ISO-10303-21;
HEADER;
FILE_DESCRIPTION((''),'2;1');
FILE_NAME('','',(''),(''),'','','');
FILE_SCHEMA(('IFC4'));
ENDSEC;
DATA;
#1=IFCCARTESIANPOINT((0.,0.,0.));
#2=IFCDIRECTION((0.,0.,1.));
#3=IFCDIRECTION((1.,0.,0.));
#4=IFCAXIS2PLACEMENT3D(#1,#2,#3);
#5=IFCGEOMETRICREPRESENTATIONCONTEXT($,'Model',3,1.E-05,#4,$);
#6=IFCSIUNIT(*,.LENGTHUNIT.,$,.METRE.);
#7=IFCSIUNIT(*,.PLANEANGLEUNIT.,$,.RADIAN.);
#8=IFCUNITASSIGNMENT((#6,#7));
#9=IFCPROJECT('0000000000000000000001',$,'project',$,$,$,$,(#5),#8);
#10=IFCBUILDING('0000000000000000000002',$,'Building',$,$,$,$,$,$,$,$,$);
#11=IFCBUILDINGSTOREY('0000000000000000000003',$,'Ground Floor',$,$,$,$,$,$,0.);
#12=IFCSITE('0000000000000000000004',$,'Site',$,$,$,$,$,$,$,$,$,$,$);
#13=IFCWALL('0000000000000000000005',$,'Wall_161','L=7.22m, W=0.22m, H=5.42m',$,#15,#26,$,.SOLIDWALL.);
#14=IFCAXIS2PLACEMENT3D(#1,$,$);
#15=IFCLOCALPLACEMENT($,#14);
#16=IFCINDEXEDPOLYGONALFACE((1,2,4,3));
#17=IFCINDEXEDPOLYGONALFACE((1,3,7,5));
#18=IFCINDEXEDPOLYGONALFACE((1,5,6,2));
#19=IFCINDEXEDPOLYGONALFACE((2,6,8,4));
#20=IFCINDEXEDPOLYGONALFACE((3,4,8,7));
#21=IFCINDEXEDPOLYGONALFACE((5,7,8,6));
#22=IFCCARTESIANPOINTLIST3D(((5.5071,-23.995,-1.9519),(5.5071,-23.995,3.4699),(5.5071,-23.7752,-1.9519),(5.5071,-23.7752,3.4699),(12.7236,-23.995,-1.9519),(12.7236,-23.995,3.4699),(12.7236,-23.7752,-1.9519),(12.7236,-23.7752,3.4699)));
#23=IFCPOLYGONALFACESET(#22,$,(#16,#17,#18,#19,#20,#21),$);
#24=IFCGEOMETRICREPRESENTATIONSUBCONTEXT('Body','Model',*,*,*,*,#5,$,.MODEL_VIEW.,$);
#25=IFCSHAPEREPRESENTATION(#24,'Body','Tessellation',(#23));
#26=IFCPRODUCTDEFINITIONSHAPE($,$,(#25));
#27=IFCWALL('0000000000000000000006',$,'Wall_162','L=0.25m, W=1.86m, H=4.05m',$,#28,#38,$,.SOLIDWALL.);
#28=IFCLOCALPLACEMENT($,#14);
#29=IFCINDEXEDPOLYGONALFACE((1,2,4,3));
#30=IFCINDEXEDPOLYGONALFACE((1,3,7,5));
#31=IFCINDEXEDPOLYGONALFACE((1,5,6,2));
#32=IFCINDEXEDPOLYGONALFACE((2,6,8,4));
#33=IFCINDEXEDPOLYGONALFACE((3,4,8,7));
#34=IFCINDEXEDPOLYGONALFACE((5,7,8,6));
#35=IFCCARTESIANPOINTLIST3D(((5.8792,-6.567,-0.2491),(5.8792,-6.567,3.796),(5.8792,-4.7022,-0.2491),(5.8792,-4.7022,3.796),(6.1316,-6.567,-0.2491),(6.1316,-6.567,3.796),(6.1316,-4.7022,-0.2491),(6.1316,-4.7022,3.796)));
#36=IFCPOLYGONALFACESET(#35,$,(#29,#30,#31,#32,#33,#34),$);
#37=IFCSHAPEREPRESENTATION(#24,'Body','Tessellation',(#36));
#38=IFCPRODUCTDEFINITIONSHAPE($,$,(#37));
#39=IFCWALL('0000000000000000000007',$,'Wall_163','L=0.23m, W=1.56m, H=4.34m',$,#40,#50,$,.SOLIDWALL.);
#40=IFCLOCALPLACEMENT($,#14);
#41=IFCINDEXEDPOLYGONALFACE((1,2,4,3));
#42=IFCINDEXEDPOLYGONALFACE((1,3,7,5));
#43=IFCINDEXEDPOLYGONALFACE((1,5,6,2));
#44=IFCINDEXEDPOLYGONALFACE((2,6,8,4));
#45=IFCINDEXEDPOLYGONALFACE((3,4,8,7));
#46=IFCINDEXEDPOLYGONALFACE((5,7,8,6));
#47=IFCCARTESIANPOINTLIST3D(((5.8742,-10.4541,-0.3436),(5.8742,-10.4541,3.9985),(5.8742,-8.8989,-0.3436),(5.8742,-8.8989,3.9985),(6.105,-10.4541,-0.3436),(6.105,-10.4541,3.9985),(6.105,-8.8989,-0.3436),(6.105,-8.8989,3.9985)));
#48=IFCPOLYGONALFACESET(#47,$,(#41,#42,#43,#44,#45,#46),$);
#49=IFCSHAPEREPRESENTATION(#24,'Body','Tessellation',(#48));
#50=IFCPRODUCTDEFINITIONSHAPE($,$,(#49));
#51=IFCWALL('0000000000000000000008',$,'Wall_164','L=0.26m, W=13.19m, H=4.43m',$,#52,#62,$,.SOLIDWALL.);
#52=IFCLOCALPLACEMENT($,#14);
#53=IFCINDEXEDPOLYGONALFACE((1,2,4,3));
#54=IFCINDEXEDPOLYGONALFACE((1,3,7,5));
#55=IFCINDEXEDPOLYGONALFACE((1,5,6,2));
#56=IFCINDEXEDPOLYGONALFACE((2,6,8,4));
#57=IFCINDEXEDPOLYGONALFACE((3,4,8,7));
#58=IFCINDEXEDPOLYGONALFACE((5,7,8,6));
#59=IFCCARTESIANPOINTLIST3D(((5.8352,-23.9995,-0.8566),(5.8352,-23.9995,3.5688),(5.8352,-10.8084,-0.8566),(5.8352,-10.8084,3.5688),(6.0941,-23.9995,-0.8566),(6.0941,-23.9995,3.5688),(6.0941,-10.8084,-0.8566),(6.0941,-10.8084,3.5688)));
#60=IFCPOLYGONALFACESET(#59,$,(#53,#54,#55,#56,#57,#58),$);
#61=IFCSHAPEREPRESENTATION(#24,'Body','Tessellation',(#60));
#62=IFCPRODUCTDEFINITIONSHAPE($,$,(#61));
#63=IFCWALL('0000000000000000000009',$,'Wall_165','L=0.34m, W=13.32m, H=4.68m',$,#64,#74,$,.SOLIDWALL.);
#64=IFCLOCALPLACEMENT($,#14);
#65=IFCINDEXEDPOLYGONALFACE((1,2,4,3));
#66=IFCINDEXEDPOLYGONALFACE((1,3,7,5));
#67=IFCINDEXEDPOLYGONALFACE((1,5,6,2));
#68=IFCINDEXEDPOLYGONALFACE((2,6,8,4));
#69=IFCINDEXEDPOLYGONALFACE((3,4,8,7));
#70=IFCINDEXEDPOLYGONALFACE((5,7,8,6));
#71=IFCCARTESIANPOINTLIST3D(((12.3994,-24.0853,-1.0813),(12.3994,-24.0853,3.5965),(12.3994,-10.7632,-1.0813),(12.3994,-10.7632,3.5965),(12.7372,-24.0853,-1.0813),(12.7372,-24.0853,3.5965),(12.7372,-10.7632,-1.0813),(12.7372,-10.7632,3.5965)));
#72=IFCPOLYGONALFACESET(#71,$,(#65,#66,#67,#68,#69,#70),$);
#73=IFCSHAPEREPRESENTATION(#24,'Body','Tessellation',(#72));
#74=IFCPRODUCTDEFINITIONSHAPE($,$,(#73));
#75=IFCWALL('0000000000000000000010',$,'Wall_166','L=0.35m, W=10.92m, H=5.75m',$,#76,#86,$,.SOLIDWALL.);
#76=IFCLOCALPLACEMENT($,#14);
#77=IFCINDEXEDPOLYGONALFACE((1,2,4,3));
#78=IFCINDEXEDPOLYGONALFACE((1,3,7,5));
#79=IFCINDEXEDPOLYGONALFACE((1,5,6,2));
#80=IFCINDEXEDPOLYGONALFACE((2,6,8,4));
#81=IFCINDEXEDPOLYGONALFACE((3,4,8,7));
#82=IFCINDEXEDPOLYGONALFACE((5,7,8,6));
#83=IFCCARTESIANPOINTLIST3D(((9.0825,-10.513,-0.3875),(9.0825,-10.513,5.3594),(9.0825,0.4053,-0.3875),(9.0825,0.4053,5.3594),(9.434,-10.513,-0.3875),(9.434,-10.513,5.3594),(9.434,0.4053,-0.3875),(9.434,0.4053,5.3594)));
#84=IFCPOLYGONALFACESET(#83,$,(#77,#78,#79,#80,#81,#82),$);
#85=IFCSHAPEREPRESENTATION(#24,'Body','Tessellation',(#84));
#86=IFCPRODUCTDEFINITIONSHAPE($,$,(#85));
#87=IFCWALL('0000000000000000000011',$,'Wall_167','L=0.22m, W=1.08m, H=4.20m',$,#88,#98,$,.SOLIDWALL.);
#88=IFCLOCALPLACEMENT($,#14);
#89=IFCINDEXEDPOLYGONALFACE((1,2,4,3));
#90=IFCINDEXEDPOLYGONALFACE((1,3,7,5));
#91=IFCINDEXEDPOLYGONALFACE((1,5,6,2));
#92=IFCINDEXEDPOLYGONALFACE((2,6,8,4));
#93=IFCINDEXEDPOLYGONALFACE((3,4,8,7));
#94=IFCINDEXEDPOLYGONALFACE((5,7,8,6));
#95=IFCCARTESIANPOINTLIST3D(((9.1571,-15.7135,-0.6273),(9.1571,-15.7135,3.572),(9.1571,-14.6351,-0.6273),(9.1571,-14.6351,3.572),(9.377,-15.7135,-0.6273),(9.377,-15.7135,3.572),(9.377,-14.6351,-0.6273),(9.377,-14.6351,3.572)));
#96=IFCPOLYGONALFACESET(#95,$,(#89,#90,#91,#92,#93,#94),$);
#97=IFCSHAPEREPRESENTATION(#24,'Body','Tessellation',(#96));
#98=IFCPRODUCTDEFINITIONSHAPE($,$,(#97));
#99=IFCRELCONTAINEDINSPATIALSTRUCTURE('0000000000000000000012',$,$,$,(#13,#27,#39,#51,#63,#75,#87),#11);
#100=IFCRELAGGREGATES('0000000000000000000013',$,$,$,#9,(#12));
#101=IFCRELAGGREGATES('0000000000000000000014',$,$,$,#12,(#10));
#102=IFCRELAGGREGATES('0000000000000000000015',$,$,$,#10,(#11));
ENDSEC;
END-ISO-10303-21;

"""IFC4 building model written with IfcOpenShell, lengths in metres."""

from ifc_helpers import new_model, si_unit, frame, origin_with_axes, origin_2d, context, subcontext, project, spatial, rectangle, extrude, element, save


model = new_model("IFC4")

# Units and contexts
model_context = context("Model", 3, precision=1e-05, world=origin_with_axes())
body_context = subcontext(model_context, "Body", "Model", "MODEL_VIEW")
ifc_project = project(units=[si_unit("LENGTHUNIT", "METRE"), si_unit("PLANEANGLEUNIT", "RADIAN")], contexts=[model_context])

# Site, building, storey
site = spatial("IfcSite", under=ifc_project, Name="Site")
building = spatial("IfcBuilding", under=site, Name="Building")
storey = spatial("IfcBuildingStorey", under=building, Name="Ground Floor", Elevation=0.0)

# Walls
element("IfcWall", 1, inside=storey, Name="Wall_161", Description="L=7.22m, W=0.22m, H=5.42m", PredefinedType="SOLIDWALL", context=body_context, shape_type="SweptSolid", body=[
    extrude(rectangle(XDim=7.2165, YDim=0.2198, at=origin_2d()), frame((9.1153, -23.8851, -1.9519), z_axis=(0.0, 0.0, 1.0), x_axis=(1.0, 0.0, 0.0)), (0.0, 0.0, 1.0), 5.4218),
])
element("IfcWall", 2, inside=storey, Name="Wall_162", Description="L=0.25m, W=1.86m, H=4.05m", PredefinedType="SOLIDWALL", context=body_context, shape_type="SweptSolid", body=[
    extrude(rectangle(XDim=0.2524, YDim=1.8648, at=origin_2d()), frame((6.0054, -5.6346, -0.2491), z_axis=(0.0, 0.0, 1.0), x_axis=(1.0, 0.0, 0.0)), (0.0, 0.0, 1.0), 4.045),
])
element("IfcWall", 3, inside=storey, Name="Wall_163", Description="L=0.23m, W=1.56m, H=4.34m", PredefinedType="SOLIDWALL", context=body_context, shape_type="SweptSolid", body=[
    extrude(rectangle(XDim=0.2308, YDim=1.5552, at=origin_2d()), frame((5.9896, -9.6765, -0.3436), z_axis=(0.0, 0.0, 1.0), x_axis=(1.0, 0.0, 0.0)), (0.0, 0.0, 1.0), 4.3422),
])
element("IfcWall", 4, inside=storey, Name="Wall_164", Description="L=0.26m, W=13.19m, H=4.43m", PredefinedType="SOLIDWALL", context=body_context, shape_type="SweptSolid", body=[
    extrude(rectangle(XDim=0.2589, YDim=13.191, at=origin_2d()), frame((5.9647, -17.4039, -0.8566), z_axis=(0.0, 0.0, 1.0), x_axis=(1.0, 0.0, 0.0)), (0.0, 0.0, 1.0), 4.4254),
])
element("IfcWall", 5, inside=storey, Name="Wall_165", Description="L=0.34m, W=13.32m, H=4.68m", PredefinedType="SOLIDWALL", context=body_context, shape_type="SweptSolid", body=[
    extrude(rectangle(XDim=0.3377, YDim=13.3221, at=origin_2d()), frame((12.5683, -17.4243, -1.0813), z_axis=(0.0, 0.0, 1.0), x_axis=(1.0, 0.0, 0.0)), (0.0, 0.0, 1.0), 4.6778),
])
element("IfcWall", 6, inside=storey, Name="Wall_166", Description="L=0.35m, W=10.92m, H=5.75m", PredefinedType="SOLIDWALL", context=body_context, shape_type="SweptSolid", body=[
    extrude(rectangle(XDim=0.3516, YDim=10.9184, at=origin_2d()), frame((9.2583, -5.0538, -0.3875), z_axis=(0.0, 0.0, 1.0), x_axis=(1.0, 0.0, 0.0)), (0.0, 0.0, 1.0), 5.747),
])
element("IfcWall", 7, inside=storey, Name="Wall_167", Description="L=0.22m, W=1.08m, H=4.20m", PredefinedType="SOLIDWALL", context=body_context, shape_type="SweptSolid", body=[
    extrude(rectangle(XDim=0.2199, YDim=1.0784, at=origin_2d()), frame((9.267, -15.1743, -0.6273), z_axis=(0.0, 0.0, 1.0), x_axis=(1.0, 0.0, 0.0)), (0.0, 0.0, 1.0), 4.1993),
])

save(model, "model.ifc")
